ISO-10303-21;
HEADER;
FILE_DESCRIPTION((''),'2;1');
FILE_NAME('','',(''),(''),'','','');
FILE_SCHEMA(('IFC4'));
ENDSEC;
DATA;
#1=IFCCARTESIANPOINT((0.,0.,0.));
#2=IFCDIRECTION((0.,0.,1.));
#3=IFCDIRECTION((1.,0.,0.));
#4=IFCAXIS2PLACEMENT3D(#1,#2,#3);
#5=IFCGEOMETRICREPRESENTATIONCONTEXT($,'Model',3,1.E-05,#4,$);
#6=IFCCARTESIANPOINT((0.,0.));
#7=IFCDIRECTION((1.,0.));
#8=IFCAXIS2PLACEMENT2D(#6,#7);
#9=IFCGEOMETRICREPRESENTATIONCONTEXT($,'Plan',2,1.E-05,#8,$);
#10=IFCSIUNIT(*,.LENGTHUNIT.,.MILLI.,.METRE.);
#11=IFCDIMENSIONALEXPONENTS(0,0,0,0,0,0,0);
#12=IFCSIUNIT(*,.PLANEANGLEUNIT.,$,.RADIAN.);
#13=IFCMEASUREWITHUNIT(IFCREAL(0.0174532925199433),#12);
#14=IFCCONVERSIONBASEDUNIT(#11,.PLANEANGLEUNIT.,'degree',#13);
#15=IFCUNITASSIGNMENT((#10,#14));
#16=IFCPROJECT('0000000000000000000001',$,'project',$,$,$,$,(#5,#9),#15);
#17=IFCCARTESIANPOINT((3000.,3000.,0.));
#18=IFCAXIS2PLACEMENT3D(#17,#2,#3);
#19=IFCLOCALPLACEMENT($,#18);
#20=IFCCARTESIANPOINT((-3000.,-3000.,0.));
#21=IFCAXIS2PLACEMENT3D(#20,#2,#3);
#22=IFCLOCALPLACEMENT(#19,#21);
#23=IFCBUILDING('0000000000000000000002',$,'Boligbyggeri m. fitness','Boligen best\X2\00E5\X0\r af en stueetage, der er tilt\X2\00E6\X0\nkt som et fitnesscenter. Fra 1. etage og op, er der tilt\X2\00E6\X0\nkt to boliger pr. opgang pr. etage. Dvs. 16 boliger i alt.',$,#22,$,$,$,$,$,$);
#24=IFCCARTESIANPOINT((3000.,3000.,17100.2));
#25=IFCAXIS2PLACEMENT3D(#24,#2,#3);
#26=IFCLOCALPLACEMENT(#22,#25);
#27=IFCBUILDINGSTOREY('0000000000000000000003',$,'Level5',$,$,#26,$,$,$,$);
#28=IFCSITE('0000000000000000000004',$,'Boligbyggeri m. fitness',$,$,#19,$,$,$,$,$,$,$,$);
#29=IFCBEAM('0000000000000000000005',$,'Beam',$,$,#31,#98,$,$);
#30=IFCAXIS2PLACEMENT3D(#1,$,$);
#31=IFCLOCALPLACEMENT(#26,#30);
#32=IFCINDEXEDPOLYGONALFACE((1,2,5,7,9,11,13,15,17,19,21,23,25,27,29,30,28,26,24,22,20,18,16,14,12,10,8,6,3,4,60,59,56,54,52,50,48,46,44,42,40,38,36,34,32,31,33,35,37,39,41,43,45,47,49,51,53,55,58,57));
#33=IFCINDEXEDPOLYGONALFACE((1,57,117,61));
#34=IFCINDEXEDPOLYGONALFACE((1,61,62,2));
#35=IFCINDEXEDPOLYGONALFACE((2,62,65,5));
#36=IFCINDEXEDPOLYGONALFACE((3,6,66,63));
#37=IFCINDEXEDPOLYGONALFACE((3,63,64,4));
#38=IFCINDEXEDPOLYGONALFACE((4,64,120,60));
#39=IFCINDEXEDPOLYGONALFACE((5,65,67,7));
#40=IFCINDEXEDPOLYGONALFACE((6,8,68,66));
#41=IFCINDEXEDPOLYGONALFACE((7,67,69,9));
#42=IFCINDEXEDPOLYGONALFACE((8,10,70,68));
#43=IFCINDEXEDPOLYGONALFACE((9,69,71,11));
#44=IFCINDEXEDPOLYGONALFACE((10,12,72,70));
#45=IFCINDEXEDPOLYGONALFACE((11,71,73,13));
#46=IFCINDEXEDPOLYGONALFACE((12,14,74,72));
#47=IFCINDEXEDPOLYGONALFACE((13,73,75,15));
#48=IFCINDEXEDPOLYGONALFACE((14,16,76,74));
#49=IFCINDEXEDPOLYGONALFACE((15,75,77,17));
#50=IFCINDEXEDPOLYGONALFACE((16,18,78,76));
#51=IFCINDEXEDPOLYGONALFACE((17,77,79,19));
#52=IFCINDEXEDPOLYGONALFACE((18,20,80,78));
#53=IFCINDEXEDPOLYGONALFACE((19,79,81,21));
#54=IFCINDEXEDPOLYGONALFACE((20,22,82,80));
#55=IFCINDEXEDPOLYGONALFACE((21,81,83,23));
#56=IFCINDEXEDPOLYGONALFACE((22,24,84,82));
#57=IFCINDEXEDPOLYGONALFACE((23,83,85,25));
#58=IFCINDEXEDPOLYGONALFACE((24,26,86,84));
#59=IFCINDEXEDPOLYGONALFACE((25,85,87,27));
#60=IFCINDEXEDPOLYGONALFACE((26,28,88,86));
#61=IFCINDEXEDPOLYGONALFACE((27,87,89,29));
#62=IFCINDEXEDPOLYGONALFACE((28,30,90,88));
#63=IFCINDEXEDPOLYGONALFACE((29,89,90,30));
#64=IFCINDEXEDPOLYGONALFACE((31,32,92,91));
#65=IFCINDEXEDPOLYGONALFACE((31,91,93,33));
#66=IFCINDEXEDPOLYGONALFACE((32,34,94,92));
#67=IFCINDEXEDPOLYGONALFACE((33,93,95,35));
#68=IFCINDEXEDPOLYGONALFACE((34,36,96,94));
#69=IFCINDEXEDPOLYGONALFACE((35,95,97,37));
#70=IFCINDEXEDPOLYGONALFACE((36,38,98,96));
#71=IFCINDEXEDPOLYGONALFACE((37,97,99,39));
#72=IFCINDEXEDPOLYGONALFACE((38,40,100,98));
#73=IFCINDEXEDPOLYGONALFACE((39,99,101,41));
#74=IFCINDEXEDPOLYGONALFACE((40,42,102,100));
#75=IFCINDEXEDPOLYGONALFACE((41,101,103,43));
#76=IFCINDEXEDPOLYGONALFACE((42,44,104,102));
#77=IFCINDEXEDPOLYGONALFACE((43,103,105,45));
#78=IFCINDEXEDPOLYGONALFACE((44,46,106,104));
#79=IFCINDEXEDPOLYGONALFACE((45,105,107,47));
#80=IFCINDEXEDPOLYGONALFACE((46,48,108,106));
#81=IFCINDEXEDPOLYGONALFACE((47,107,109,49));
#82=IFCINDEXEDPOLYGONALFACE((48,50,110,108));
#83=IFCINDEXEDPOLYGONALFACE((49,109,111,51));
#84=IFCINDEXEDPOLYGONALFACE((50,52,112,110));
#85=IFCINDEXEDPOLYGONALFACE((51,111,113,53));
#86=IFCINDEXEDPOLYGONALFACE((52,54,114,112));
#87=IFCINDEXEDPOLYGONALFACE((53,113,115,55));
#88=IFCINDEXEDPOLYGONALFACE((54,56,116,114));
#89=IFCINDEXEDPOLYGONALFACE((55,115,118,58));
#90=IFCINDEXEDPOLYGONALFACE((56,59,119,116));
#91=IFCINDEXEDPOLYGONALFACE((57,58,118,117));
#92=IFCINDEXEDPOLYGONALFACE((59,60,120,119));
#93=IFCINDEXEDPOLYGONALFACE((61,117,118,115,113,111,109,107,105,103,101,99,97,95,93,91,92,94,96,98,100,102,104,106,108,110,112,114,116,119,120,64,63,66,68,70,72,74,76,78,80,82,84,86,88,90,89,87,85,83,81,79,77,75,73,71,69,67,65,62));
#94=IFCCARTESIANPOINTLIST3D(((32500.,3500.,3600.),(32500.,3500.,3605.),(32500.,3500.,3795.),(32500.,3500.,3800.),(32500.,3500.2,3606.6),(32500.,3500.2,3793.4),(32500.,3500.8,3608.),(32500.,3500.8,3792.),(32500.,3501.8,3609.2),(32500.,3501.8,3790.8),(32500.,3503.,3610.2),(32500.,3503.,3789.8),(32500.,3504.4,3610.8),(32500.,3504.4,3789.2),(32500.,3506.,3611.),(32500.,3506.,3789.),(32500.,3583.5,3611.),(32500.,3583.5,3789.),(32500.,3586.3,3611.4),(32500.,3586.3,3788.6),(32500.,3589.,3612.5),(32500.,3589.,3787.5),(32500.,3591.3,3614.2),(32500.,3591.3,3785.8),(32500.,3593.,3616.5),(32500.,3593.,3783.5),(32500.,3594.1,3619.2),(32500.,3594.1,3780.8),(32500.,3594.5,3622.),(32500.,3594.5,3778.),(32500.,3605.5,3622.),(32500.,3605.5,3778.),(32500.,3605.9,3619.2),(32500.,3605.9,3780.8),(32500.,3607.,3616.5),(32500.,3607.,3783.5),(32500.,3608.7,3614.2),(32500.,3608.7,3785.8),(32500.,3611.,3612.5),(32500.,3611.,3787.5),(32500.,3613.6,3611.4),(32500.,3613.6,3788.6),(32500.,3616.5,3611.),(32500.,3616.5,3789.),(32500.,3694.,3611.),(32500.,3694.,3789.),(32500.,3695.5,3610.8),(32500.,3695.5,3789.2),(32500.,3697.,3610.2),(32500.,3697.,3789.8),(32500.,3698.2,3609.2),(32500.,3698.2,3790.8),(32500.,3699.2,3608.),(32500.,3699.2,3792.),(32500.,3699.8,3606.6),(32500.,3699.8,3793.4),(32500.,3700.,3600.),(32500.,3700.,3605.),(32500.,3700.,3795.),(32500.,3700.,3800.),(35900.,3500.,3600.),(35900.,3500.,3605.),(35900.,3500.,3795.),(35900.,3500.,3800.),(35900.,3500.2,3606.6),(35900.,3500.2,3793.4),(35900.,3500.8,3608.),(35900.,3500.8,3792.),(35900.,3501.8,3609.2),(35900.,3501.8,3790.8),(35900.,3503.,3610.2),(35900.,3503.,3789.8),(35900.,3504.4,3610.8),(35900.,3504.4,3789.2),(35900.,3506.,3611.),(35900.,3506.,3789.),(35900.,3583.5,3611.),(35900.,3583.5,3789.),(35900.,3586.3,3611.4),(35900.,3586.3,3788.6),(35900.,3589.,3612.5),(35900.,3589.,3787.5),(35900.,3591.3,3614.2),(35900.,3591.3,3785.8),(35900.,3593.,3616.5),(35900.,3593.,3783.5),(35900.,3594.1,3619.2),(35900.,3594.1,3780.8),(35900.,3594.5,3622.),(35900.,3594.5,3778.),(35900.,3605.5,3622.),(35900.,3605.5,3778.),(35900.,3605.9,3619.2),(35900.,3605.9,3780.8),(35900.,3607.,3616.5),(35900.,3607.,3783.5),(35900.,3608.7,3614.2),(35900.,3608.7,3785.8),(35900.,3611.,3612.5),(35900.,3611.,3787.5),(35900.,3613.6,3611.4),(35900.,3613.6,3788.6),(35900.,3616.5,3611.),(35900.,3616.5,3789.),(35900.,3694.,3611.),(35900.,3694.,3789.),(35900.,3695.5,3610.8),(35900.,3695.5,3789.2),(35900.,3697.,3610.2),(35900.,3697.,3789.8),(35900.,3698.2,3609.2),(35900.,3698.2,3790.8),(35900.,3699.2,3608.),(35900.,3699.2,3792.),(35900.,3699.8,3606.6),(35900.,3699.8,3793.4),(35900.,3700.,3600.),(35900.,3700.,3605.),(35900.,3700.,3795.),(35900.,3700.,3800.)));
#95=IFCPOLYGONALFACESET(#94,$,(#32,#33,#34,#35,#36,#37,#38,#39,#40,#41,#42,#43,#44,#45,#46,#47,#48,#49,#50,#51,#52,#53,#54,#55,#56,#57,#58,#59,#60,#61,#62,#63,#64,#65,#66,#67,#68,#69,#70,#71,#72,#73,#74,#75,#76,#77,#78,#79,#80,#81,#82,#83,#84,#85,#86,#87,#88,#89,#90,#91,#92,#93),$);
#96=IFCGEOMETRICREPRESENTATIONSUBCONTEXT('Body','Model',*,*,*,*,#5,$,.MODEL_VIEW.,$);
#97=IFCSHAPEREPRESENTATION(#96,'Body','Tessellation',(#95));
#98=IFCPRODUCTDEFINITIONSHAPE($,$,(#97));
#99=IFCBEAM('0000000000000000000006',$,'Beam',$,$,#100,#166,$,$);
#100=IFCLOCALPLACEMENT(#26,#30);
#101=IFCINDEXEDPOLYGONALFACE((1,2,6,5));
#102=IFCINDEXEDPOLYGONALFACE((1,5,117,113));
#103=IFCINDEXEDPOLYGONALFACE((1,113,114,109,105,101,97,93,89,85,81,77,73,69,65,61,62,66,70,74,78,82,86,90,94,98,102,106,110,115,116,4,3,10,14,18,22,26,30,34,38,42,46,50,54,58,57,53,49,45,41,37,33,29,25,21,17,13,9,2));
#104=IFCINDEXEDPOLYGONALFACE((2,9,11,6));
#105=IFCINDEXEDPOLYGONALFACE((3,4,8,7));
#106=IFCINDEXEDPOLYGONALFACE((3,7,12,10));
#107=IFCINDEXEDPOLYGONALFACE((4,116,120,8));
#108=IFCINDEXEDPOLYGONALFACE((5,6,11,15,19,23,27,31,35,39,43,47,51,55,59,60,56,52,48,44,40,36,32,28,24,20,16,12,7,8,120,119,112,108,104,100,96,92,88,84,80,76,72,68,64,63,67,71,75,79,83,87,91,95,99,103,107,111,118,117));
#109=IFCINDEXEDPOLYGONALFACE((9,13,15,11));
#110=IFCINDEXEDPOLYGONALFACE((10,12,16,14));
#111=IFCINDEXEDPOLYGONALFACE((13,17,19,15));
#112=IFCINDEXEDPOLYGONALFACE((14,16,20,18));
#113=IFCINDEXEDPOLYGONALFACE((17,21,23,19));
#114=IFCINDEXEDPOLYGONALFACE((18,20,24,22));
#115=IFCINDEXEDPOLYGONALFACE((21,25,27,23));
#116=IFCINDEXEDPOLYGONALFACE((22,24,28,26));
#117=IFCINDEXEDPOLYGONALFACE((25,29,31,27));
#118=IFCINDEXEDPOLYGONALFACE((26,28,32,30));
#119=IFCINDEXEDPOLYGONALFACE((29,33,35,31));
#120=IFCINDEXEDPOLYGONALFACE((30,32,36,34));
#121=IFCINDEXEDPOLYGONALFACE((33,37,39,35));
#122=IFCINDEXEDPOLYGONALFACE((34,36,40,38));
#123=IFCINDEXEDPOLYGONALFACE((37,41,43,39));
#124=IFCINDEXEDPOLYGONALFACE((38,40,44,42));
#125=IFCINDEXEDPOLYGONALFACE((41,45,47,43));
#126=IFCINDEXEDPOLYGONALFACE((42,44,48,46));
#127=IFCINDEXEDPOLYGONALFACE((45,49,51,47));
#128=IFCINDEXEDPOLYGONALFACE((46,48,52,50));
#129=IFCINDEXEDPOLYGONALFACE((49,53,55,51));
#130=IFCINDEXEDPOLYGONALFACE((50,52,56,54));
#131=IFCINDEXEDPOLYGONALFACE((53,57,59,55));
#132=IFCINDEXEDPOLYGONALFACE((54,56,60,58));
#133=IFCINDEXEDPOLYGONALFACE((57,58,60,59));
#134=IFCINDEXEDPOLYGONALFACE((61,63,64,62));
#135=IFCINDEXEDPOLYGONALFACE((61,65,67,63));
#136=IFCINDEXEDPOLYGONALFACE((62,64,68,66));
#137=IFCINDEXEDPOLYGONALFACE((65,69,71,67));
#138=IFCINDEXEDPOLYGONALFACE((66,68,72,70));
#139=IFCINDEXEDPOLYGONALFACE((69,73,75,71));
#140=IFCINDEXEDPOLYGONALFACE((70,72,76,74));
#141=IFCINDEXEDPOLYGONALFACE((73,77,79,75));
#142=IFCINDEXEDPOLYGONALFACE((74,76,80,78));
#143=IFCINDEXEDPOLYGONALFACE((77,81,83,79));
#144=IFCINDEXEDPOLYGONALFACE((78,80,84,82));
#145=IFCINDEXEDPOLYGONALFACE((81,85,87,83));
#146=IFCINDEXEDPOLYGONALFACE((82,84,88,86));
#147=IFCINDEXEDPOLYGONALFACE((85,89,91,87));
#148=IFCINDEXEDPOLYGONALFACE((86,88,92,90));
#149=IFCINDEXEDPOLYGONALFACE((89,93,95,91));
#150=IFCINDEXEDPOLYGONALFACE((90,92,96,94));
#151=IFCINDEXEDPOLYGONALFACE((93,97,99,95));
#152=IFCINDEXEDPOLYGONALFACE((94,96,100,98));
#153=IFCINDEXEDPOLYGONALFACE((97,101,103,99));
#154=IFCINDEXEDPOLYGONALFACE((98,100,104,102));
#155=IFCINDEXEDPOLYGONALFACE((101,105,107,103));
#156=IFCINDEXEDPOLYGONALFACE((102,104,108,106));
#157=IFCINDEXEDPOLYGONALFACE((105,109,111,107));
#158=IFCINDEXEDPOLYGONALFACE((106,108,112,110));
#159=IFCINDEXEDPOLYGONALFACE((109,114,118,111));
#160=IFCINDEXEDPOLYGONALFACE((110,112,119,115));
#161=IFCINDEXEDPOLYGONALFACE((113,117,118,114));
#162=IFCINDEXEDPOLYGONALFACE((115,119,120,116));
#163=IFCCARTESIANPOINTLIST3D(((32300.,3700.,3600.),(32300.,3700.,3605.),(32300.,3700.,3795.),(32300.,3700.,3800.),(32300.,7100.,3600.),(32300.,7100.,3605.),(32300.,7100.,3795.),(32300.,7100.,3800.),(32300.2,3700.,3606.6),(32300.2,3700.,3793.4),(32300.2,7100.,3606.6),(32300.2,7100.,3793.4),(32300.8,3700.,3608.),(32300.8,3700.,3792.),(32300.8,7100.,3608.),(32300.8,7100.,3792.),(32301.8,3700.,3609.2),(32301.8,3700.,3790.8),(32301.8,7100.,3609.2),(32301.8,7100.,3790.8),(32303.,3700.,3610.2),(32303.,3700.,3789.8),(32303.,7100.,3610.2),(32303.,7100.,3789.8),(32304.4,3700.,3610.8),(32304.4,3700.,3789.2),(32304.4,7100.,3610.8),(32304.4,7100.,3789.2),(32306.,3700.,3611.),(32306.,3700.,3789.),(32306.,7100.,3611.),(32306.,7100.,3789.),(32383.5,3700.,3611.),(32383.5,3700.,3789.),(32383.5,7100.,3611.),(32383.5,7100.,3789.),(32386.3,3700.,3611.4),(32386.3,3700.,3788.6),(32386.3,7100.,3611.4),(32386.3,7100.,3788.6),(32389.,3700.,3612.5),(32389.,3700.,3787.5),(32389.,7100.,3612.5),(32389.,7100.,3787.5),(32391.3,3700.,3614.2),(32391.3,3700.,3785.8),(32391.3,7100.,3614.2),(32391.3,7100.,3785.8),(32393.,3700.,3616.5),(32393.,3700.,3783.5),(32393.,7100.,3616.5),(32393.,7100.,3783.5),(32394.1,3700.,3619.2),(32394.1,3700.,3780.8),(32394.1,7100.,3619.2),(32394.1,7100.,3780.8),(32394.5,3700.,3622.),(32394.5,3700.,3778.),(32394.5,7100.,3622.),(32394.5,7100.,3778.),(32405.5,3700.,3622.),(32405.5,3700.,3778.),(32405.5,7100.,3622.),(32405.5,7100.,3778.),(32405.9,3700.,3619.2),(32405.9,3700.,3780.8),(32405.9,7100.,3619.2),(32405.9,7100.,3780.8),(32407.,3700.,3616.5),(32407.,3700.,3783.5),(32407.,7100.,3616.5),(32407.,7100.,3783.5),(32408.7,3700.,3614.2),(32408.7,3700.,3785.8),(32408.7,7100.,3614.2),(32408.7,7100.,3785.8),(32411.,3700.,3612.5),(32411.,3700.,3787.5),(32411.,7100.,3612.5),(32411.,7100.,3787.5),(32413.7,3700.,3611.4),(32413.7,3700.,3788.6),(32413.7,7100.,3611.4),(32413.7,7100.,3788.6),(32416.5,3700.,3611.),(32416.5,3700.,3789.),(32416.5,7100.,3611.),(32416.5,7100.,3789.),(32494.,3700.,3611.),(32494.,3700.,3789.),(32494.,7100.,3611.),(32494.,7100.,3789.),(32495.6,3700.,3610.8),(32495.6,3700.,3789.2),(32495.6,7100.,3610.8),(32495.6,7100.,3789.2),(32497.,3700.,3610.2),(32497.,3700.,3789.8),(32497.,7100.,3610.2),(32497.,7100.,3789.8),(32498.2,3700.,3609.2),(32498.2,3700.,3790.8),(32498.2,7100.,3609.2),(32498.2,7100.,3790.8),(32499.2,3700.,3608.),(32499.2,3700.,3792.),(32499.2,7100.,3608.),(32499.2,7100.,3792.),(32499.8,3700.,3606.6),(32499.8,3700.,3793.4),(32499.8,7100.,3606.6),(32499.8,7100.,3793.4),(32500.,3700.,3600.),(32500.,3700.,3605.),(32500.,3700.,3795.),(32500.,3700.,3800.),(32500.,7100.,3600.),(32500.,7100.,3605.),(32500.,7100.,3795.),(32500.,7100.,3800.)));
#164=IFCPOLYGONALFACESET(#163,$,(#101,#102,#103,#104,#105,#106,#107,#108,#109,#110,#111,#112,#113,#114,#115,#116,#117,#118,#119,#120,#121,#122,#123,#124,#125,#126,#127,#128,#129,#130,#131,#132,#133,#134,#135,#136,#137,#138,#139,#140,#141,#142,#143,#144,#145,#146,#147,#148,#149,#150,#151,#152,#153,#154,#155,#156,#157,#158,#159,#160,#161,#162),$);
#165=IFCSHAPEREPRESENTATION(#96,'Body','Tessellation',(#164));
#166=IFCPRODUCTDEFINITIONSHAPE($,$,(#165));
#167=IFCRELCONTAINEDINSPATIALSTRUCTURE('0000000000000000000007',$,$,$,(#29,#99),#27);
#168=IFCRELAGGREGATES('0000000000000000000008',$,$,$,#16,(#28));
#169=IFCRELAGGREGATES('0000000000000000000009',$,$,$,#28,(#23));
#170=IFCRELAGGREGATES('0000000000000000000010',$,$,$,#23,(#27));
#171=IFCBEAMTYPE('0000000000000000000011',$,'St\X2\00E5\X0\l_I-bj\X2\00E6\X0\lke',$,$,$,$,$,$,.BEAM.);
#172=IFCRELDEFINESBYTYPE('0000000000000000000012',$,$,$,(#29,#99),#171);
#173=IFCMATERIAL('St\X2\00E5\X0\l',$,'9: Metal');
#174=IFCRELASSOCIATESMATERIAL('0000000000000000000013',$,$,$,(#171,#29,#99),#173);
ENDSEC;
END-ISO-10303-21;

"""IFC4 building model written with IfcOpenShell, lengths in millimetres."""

from ifc_helpers import new_model, entity, si_unit, converted_unit, frame, origin_with_axes, origin_2d_with_axis, place, context, subcontext, project, spatial, i_section, extrude, material, material_profile, profile_set, profile_usage, type_object, element, save


model = new_model("IFC4")

# Units and contexts
model_context = context("Model", 3, precision=1e-05, world=origin_with_axes())
plan_context = context("Plan", 2, precision=1e-05, world=origin_2d_with_axis())
body_context = subcontext(model_context, "Body", "Model", "MODEL_VIEW")
ifc_project = project(units=[si_unit("LENGTHUNIT", "METRE", prefix="MILLI"), converted_unit("PLANEANGLEUNIT", "degree", entity("IfcReal", 0.0174532925199433), si_unit("PLANEANGLEUNIT", "RADIAN"), dimensions=[0, 0, 0, 0, 0, 0, 0])], contexts=[model_context, plan_context])

# Site, building, storey
site_placement = place(None, frame((3000.0, 3000.0, 0.0), z_axis=(0.0, 0.0, 1.0), x_axis=(1.0, 0.0, 0.0)))
site = spatial("IfcSite", under=ifc_project, at=site_placement, Name="Boligbyggeri m. fitness")
building_placement = place(site_placement, frame((-3000.0, -3000.0, 0.0), z_axis=(0.0, 0.0, 1.0), x_axis=(1.0, 0.0, 0.0)))
building = spatial("IfcBuilding", under=site, at=building_placement, Name="Boligbyggeri m. fitness", Description="Boligen består af en stueetage, der er tiltænkt som et fitnesscenter. Fra 1. etage og op, er der tiltænkt to boliger pr. opgang pr. etage. Dvs. 16 boliger i alt.")
storey_placement = place(building_placement, frame((3000.0, 3000.0, 17100.2), z_axis=(0.0, 0.0, 1.0), x_axis=(1.0, 0.0, 0.0)))
storey = spatial("IfcBuildingStorey", under=building, at=storey_placement, Name="Level5")

# Beams
ifc_material_1 = material(Name="Stål", Category="9: Metal")
ifc_material_profile_1 = material_profile(ifc_material_1, i_section(OverallWidth=200.0, OverallDepth=200.0, WebThickness=11.0, FlangeThickness=11.0, FilletRadius=11.0, FlangeEdgeRadius=6.0), Name="Stål", Category="9: Metal")
ifc_profile_set_1 = profile_set([ifc_material_profile_1], Name="NY_I-Profil")
beam_type = type_object("IfcBeamType", Name="Stål_I-bjælke", PredefinedType="BEAM", material=ifc_profile_set_1)
ifc_profile_usage_1 = profile_usage(ifc_profile_set_1, cardinal=7)
beam_1_placement = place(storey_placement, frame((32500.0, 3700.0, 3800.0), z_axis=(1.0, 0.0, 0.0), x_axis=(0.0, 1.0, 0.0)))
element("IfcBeam", 1, at=beam_1_placement, inside=storey, type_object=beam_type, material=ifc_profile_usage_1, Name="Beam", context=body_context, shape_type="SweptSolid", body=[
    extrude(i_section(OverallWidth=200.0, OverallDepth=200.0, WebThickness=11.0, FlangeThickness=11.0, FilletRadius=11.0, FlangeEdgeRadius=6.0), frame((-100.0, -100.0, 0.0), z_axis=(0.0, 0.0, 1.0), x_axis=(1.0, 0.0, 0.0)), (0.0, 0.0, 1.0), 3400.0),
])
ifc_profile_usage_2 = profile_usage(ifc_profile_set_1, cardinal=9)
beam_2_placement = place(storey_placement, frame((32500.0, 3700.0, 3800.0), z_axis=(0.0, 1.0, 0.0), x_axis=(-1.0, 0.0, 0.0)))
element("IfcBeam", 2, at=beam_2_placement, inside=storey, type_object=beam_type, material=ifc_profile_usage_2, Name="Beam", context=body_context, shape_type="SweptSolid", body=[
    extrude(i_section(OverallWidth=200.0, OverallDepth=200.0, WebThickness=11.0, FlangeThickness=11.0, FilletRadius=11.0, FlangeEdgeRadius=6.0), frame((100.0, -100.0, 0.0), z_axis=(0.0, 0.0, 1.0), x_axis=(1.0, 0.0, 0.0)), (0.0, 0.0, 1.0), 3400.0),
])

save(model, "model.ifc")
